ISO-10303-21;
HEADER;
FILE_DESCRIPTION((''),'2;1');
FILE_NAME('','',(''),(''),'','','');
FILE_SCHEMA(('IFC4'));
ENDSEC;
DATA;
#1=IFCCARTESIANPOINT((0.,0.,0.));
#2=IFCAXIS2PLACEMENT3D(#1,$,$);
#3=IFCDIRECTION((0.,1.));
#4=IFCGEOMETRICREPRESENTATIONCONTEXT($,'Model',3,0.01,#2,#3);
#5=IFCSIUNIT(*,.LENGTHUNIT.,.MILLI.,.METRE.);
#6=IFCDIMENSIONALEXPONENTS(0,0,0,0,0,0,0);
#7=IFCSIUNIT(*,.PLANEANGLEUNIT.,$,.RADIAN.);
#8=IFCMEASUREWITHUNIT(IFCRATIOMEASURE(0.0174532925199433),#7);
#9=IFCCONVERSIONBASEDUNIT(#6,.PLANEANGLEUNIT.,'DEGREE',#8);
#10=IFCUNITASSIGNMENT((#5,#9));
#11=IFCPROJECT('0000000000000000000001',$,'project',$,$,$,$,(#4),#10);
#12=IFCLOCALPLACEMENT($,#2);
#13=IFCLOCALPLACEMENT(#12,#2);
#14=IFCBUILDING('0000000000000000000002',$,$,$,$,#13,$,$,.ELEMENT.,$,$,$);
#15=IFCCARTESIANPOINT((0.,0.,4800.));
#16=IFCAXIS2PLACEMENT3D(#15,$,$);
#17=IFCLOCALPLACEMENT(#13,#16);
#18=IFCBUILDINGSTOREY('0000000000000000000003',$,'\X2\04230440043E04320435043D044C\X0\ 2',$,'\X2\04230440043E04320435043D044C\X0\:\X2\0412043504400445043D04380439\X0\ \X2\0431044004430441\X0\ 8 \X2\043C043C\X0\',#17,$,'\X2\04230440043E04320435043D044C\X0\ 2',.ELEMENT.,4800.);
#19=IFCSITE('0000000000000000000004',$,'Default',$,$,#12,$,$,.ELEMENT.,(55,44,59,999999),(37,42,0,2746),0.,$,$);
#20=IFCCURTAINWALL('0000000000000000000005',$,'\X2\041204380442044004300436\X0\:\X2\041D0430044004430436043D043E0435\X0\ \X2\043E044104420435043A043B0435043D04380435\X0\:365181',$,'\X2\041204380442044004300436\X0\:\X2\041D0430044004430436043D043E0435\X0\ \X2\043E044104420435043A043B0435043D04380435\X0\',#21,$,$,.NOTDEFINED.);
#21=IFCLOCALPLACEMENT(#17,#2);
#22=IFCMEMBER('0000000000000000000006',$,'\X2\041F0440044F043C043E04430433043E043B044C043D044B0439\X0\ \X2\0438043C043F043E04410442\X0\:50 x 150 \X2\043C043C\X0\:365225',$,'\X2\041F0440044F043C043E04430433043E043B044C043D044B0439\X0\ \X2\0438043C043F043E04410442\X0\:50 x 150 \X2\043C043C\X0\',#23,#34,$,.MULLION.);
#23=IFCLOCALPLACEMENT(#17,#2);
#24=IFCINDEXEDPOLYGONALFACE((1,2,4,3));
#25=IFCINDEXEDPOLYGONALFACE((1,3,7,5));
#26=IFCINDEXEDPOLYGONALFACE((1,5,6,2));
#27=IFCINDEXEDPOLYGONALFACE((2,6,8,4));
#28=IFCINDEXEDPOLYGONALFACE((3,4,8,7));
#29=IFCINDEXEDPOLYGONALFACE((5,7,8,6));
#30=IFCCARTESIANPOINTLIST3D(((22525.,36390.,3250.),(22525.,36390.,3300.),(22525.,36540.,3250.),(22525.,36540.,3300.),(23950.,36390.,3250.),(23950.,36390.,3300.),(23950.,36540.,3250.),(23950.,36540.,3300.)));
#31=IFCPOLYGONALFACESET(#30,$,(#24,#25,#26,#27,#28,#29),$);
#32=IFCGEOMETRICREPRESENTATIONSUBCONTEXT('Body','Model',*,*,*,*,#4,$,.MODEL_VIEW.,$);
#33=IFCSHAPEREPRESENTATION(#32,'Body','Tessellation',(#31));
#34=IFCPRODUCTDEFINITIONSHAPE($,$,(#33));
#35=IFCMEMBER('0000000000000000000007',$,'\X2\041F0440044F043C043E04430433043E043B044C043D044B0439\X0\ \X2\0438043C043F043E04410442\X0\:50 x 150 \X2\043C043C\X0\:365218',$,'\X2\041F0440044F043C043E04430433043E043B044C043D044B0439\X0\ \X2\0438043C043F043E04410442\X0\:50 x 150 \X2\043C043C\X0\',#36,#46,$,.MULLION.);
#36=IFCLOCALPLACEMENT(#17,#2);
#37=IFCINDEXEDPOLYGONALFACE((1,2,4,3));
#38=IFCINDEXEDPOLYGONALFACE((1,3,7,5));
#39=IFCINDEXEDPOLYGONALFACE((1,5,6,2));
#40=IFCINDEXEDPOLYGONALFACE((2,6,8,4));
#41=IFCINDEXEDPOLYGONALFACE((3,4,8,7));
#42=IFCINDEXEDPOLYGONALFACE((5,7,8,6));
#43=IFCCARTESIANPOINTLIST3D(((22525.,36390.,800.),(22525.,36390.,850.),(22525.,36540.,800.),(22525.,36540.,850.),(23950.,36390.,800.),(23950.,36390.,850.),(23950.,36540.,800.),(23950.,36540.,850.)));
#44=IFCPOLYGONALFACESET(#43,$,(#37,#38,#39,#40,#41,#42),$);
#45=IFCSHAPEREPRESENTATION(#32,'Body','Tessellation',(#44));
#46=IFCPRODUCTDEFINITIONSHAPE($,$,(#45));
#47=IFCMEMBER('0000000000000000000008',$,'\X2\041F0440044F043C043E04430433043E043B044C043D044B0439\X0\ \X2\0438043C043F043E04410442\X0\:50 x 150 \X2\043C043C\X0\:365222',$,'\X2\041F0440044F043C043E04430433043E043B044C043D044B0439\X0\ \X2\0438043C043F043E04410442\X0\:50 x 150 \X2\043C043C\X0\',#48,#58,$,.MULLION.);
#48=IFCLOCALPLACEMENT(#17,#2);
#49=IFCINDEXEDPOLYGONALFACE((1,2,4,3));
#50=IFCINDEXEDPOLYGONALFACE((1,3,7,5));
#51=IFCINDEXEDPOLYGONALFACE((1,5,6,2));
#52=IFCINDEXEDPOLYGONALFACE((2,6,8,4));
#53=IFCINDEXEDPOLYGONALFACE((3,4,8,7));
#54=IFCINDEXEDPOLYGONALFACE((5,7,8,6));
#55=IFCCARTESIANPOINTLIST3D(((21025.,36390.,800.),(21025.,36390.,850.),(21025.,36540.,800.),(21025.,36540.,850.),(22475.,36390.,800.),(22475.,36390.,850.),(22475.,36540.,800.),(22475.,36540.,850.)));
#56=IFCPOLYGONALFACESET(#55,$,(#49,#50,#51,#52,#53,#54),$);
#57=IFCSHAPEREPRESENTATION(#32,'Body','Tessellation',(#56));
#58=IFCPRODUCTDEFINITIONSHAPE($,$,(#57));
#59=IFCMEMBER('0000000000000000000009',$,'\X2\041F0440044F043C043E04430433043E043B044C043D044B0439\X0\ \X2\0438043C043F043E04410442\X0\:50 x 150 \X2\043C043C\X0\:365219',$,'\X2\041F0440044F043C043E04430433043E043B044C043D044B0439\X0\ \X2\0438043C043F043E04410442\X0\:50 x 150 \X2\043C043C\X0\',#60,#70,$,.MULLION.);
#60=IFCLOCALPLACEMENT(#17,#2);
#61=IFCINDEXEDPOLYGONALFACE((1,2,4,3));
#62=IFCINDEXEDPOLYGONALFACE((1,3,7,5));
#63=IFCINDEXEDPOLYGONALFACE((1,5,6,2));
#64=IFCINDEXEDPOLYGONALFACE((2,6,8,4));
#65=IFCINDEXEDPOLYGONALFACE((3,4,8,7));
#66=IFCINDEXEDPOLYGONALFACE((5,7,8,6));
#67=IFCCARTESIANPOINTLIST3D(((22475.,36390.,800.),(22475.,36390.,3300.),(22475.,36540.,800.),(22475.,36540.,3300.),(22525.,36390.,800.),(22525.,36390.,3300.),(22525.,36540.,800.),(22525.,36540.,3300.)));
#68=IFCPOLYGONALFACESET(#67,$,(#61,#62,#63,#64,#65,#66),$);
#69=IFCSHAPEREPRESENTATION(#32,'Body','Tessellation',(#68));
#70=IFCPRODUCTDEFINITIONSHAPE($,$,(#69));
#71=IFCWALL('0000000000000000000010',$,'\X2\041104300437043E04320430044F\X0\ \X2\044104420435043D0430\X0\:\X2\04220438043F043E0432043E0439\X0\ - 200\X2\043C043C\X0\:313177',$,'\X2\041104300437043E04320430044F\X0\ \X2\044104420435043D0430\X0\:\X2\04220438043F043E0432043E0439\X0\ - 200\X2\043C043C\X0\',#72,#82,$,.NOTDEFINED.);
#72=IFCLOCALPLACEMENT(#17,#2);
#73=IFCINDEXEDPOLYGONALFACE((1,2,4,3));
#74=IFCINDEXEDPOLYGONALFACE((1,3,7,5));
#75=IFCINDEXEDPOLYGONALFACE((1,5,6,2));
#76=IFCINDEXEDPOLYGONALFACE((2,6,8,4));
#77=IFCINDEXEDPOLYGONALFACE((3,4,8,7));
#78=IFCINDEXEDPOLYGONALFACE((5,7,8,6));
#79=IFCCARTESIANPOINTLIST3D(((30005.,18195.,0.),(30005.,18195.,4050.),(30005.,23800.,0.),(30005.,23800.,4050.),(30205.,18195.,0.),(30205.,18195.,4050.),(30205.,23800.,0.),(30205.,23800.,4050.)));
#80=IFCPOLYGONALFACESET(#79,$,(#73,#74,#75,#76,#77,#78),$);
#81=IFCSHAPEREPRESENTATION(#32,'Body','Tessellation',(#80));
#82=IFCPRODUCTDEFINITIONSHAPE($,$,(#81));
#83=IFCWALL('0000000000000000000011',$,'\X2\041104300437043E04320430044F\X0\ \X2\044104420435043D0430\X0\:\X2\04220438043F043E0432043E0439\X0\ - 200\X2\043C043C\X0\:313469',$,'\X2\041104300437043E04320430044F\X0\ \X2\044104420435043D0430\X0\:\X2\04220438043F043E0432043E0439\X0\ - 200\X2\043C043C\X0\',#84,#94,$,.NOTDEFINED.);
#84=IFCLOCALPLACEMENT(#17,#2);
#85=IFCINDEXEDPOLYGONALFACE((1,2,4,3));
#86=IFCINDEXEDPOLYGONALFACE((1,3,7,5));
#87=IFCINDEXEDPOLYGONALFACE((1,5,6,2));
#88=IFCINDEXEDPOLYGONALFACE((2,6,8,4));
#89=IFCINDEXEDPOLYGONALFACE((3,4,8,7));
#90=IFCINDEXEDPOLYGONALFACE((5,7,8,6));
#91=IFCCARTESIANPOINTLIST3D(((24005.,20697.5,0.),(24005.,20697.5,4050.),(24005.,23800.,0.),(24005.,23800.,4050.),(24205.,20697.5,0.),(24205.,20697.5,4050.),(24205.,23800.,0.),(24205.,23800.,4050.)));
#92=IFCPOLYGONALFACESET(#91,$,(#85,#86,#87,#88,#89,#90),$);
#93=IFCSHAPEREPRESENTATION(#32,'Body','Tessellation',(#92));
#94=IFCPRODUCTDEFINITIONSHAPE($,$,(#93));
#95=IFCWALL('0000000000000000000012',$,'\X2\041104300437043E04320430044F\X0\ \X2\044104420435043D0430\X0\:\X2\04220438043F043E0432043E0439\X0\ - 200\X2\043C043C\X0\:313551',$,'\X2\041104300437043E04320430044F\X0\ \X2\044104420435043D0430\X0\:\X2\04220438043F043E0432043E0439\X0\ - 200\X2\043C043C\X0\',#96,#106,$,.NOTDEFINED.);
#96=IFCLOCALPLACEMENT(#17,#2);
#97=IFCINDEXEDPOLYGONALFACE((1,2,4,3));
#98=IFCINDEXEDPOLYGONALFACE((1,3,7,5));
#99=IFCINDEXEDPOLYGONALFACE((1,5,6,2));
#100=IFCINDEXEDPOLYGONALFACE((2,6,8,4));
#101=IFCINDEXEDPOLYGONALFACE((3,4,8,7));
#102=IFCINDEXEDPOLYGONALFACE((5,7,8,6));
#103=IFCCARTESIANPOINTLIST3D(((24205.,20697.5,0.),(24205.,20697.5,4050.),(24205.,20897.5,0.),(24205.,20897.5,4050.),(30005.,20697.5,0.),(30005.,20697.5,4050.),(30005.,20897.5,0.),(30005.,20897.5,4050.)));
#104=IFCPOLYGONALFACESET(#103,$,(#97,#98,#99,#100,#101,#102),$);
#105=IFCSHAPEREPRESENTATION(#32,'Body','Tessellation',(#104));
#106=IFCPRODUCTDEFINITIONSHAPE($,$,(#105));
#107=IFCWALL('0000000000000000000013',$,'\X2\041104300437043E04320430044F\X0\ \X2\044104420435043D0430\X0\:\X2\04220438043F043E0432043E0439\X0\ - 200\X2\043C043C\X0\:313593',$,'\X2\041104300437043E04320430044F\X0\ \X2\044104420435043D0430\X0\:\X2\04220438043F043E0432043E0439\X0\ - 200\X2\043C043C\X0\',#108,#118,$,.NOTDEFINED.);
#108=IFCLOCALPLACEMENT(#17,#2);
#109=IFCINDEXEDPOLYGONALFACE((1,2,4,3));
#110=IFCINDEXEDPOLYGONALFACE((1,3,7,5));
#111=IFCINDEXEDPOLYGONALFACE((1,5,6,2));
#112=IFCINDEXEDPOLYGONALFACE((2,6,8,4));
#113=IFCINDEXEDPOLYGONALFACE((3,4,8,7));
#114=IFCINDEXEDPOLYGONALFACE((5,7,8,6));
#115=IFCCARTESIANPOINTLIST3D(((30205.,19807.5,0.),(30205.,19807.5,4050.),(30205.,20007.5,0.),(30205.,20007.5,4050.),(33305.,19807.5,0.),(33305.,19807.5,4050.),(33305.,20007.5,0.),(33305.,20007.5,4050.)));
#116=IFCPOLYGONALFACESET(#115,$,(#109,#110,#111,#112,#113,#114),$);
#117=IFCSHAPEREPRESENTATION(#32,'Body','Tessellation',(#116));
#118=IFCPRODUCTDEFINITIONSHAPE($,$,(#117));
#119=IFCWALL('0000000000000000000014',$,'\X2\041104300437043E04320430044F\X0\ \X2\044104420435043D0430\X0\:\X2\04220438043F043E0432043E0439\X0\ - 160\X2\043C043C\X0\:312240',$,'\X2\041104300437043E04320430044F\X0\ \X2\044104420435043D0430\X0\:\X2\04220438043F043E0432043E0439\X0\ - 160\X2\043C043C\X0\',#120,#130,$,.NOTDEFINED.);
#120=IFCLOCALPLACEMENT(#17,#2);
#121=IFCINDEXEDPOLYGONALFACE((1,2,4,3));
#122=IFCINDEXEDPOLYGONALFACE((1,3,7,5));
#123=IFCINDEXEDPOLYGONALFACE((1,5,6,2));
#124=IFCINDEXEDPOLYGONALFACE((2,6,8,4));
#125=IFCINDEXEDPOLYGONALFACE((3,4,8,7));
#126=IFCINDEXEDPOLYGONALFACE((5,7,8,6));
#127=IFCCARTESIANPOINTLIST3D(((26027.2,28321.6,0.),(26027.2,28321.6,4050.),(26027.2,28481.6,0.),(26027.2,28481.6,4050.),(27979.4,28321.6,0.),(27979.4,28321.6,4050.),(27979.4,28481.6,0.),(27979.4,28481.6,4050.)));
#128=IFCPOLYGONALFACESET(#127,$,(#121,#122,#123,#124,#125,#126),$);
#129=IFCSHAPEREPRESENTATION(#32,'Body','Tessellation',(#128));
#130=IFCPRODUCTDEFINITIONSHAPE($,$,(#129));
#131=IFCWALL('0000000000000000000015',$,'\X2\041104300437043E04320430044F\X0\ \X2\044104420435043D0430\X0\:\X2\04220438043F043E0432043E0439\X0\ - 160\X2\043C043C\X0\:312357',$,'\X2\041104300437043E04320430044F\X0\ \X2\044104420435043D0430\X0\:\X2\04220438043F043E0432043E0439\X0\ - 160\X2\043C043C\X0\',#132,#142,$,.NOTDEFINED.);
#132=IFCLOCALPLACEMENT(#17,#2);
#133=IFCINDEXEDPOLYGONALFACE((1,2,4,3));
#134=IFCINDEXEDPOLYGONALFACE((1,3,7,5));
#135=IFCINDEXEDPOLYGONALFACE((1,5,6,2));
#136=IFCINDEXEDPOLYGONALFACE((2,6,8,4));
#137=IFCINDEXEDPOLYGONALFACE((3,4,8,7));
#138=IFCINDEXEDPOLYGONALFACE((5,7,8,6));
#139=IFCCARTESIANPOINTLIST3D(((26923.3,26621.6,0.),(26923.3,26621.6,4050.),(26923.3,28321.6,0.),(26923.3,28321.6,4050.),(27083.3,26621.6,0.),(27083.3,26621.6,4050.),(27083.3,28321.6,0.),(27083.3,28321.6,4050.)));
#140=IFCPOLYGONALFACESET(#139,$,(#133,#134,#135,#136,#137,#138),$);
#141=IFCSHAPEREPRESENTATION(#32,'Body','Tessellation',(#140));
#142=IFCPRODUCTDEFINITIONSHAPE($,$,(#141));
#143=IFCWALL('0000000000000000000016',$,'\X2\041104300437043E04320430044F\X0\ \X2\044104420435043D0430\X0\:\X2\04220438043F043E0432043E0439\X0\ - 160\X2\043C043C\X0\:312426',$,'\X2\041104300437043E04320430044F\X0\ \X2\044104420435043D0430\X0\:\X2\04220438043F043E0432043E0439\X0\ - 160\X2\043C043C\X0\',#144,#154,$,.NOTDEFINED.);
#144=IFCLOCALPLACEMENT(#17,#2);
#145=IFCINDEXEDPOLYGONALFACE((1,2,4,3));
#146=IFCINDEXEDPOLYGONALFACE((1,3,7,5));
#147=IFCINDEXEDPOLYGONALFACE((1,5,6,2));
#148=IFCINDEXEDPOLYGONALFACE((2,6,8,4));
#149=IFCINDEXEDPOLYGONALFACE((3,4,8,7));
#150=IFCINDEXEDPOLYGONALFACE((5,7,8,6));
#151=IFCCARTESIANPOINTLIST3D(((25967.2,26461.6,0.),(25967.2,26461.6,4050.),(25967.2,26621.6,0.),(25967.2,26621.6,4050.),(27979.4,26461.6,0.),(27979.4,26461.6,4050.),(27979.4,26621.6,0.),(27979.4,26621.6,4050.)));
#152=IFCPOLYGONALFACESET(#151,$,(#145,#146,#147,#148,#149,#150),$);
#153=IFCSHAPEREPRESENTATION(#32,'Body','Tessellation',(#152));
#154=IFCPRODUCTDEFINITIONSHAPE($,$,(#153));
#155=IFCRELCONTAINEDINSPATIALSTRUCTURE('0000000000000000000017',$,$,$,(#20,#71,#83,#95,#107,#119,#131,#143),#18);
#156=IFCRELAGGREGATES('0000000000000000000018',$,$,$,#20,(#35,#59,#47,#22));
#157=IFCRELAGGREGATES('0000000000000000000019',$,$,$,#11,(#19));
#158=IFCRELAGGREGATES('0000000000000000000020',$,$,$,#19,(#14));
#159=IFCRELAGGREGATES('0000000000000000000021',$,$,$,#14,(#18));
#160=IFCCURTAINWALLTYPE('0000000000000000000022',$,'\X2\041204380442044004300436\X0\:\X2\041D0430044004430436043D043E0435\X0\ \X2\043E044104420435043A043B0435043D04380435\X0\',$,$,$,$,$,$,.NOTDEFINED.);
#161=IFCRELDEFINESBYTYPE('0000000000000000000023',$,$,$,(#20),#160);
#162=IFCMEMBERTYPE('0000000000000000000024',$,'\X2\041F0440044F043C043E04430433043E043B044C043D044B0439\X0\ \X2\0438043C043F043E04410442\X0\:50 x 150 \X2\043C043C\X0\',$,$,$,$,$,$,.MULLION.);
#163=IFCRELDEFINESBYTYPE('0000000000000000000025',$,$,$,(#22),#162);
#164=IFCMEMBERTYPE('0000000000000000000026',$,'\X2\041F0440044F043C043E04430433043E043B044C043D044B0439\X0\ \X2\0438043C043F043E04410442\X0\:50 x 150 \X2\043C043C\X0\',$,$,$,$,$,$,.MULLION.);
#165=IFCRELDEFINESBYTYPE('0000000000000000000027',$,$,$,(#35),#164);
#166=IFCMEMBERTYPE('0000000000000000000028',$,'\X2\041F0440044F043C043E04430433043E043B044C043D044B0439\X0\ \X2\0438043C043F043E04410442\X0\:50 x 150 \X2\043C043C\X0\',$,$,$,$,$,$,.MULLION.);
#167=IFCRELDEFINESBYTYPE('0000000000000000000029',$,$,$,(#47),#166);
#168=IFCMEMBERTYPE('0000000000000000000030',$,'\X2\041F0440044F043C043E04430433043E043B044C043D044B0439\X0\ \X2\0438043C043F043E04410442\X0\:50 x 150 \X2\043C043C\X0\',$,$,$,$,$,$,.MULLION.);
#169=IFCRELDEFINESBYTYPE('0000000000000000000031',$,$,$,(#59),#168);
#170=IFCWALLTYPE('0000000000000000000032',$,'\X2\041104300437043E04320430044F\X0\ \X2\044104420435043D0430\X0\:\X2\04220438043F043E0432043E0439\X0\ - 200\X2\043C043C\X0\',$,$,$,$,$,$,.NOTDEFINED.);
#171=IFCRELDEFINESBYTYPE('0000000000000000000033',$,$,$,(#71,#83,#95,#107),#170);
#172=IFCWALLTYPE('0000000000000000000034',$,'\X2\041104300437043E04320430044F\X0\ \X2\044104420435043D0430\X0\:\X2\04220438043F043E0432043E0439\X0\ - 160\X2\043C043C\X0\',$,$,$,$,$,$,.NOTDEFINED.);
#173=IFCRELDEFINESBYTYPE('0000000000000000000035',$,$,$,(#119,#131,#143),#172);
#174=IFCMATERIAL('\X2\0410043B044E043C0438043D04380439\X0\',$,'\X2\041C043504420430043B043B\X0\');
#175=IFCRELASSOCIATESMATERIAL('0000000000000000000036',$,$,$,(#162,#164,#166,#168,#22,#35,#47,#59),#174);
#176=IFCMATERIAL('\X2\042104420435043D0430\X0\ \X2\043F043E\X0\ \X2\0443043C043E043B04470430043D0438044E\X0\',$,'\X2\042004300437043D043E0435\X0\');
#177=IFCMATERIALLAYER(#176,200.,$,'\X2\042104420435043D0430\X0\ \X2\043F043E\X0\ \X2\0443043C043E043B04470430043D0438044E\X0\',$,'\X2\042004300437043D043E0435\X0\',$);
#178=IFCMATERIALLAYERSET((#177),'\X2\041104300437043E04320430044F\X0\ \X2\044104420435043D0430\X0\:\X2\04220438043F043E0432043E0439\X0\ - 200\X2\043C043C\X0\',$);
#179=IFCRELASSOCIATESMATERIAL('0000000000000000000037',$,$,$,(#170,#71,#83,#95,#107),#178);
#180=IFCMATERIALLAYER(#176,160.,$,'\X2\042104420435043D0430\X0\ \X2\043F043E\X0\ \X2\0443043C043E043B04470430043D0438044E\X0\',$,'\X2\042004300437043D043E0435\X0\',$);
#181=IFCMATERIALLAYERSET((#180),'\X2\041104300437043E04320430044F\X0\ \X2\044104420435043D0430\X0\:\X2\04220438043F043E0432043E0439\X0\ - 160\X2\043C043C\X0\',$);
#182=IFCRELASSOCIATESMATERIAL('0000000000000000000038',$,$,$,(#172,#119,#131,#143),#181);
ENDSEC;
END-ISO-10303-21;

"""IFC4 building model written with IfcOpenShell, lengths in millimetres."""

from ifc_helpers import new_model, entity, si_unit, converted_unit, direction, frame, frame_2d, origin, origin_2d_with_axis, place, context, subcontext, project, spatial, rectangle, extrude, source, transform, mapped, material, layer, layer_set, layer_usage, material_profile, profile_set, profile_usage, type_object, type_shapes, element, aggregate, save


model = new_model("IFC4")

# Units and contexts
model_context = context("Model", 3, precision=0.01, world=origin(), true_north=direction((0.0, 1.0)))
body_context = subcontext(model_context, "Body", "Model", "MODEL_VIEW")
ifc_project = project(units=[si_unit("LENGTHUNIT", "METRE", prefix="MILLI"), converted_unit("PLANEANGLEUNIT", "DEGREE", entity("IfcRatioMeasure", 0.0174532925199433), si_unit("PLANEANGLEUNIT", "RADIAN"), dimensions=[0, 0, 0, 0, 0, 0, 0])], contexts=[model_context])

# Site, building, storey
site_placement = place(None, origin())
site = spatial("IfcSite", under=ifc_project, at=site_placement, Name="Default", CompositionType="ELEMENT", RefLatitude=(55, 44, 59, 999999), RefLongitude=(37, 42, 0, 2746), RefElevation=0.0)
building_placement = place(site_placement, origin())
building = spatial("IfcBuilding", under=site, at=building_placement, CompositionType="ELEMENT")
storey_placement = place(building_placement, frame((0.0, 0.0, 4800.0)))
storey = spatial("IfcBuildingStorey", under=building, at=storey_placement, Name="Уровень 2", ObjectType="Уровень:Верхний брус 8 мм", LongName="Уровень 2", CompositionType="ELEMENT", Elevation=4800.0)

# Curtain wall, members
curtain_wall_type = type_object("IfcCurtainWallType", Name="Витраж:Наружное остекление", PredefinedType="NOTDEFINED")
curtain_wall_1_placement = place(storey_placement, frame((0.0, 0.0, -4800.0)))
curtain_wall_1 = element("IfcCurtainWall", 1, at=curtain_wall_1_placement, inside=storey, type_object=curtain_wall_type, Name="Витраж:Наружное остекление:365181", ObjectType="Витраж:Наружное остекление", PredefinedType="NOTDEFINED")
ifc_material_1 = material(Name="Алюминий", Category="Металл")
ifc_material_profile = material_profile(ifc_material_1, rectangle(XDim=150.0, YDim=50.0, at=origin_2d_with_axis()), Name="50 x 150 мм")
ifc_profile_set = profile_set([ifc_material_profile], Name="50 x 150 мм")
ifc_profile_usage_1 = profile_usage(ifc_profile_set)
member_type_1 = type_object("IfcMemberType", Name="Прямоугольный импост:50 x 150 мм", PredefinedType="MULLION", material=ifc_profile_set)
shared_shape_1 = source(origin(), body_context, "Body", "SweptSolid", [
    extrude(rectangle(XDim=150.0, YDim=50.0, at=origin_2d_with_axis()), frame((-25.0, 0.0, -1425.0), z_axis=(0.0, 0.0, 1.0), x_axis=(0.0, -1.0, 0.0)), (0.0, 0.0, 1.0), 1425.0),
])
type_shapes(member_type_1, [shared_shape_1])
member_1_placement = place(storey_placement, frame((22525.0, 36465.0, 3300.0), z_axis=(-1.0, 0.0, 0.0), x_axis=(0.0, 0.0, 1.0)))
member_1 = element("IfcMember", 2, at=member_1_placement, type_object=member_type_1, material=ifc_profile_usage_1, Name="Прямоугольный импост:50 x 150 мм:365225", ObjectType="Прямоугольный импост:50 x 150 мм", PredefinedType="MULLION", context=body_context, shape_type="MappedRepresentation", body=[
    mapped(shared_shape_1, transform((0.0, 0.0, 0.0), scale=1.0)),
])
ifc_profile_usage_2 = profile_usage(ifc_profile_set)
member_type_2 = type_object("IfcMemberType", Name="Прямоугольный импост:50 x 150 мм", PredefinedType="MULLION", material=ifc_profile_set)
shared_shape_2 = source(origin(), body_context, "Body", "SweptSolid", [
    extrude(rectangle(XDim=150.0, YDim=50.0, at=origin_2d_with_axis()), frame((-25.0, 0.0, -1425.0), z_axis=(0.0, 0.0, 1.0), x_axis=(0.0, -1.0, 0.0)), (0.0, 0.0, 1.0), 1425.0),
])
type_shapes(member_type_2, [shared_shape_2])
member_2_placement = place(storey_placement, frame((23950.0, 36465.0, 800.0), z_axis=(1.0, 0.0, 0.0), x_axis=(0.0, 0.0, -1.0)))
member_2 = element("IfcMember", 3, at=member_2_placement, type_object=member_type_2, material=ifc_profile_usage_2, Name="Прямоугольный импост:50 x 150 мм:365218", ObjectType="Прямоугольный импост:50 x 150 мм", PredefinedType="MULLION", context=body_context, shape_type="MappedRepresentation", body=[
    mapped(shared_shape_2, transform((0.0, 0.0, 0.0), scale=1.0)),
])
ifc_profile_usage_3 = profile_usage(ifc_profile_set)
member_type_3 = type_object("IfcMemberType", Name="Прямоугольный импост:50 x 150 мм", PredefinedType="MULLION", material=ifc_profile_set)
shared_shape_3 = source(origin(), body_context, "Body", "SweptSolid", [
    extrude(rectangle(XDim=150.0, YDim=50.0, at=origin_2d_with_axis()), frame((-25.0, 0.0, -1450.0), z_axis=(0.0, 0.0, 1.0), x_axis=(0.0, -1.0, 0.0)), (0.0, 0.0, 1.0), 1450.0),
])
type_shapes(member_type_3, [shared_shape_3])
member_3_placement = place(storey_placement, frame((22475.0, 36465.0, 800.0), z_axis=(1.0, 0.0, 0.0), x_axis=(0.0, 0.0, -1.0)))
member_3 = element("IfcMember", 4, at=member_3_placement, type_object=member_type_3, material=ifc_profile_usage_3, Name="Прямоугольный импост:50 x 150 мм:365222", ObjectType="Прямоугольный импост:50 x 150 мм", PredefinedType="MULLION", context=body_context, shape_type="MappedRepresentation", body=[
    mapped(shared_shape_3, transform((0.0, 0.0, 0.0), scale=1.0)),
])
ifc_profile_usage_4 = profile_usage(ifc_profile_set)
member_type_4 = type_object("IfcMemberType", Name="Прямоугольный импост:50 x 150 мм", PredefinedType="MULLION", material=ifc_profile_set)
shared_shape_4 = source(origin(), body_context, "Body", "SweptSolid", [
    extrude(rectangle(XDim=150.0, YDim=50.0, at=origin_2d_with_axis()), frame((0.0, 0.0, -2500.0), z_axis=(0.0, 0.0, 1.0), x_axis=(0.0, -1.0, 0.0)), (0.0, 0.0, 1.0), 2500.0),
])
type_shapes(member_type_4, [shared_shape_4])
member_4_placement = place(storey_placement, frame((22500.0, 36465.0, 800.0), z_axis=(0.0, 0.0, -1.0), x_axis=(-1.0, 0.0, 0.0)))
member_4 = element("IfcMember", 5, at=member_4_placement, type_object=member_type_4, material=ifc_profile_usage_4, Name="Прямоугольный импост:50 x 150 мм:365219", ObjectType="Прямоугольный импост:50 x 150 мм", PredefinedType="MULLION", context=body_context, shape_type="MappedRepresentation", body=[
    mapped(shared_shape_4, transform((0.0, 0.0, 0.0), scale=1.0)),
])

aggregate(curtain_wall_1, [member_2, member_4, member_3, member_1])

# Shared definitions
ifc_material_2 = material(Name="Стена по умолчанию", Category="Разное")
ifc_layer_1 = layer(ifc_material_2, 200.0, Name="Стена по умолчанию", Category="Разное")
ifc_layer_set_1 = layer_set([ifc_layer_1], Name="Базовая стена:Типовой - 200мм")
wall_type_1 = type_object("IfcWallType", Name="Базовая стена:Типовой - 200мм", PredefinedType="NOTDEFINED", material=ifc_layer_set_1)

# Walls
ifc_layer_usage_1 = layer_usage(ifc_layer_set_1, "AXIS2", "NEGATIVE", 100.0)
wall_1_placement = place(storey_placement, frame((30105.0, 23800.0, 0.0), z_axis=(0.0, 0.0, 1.0), x_axis=(0.0, -1.0, 0.0)))
element("IfcWall", 6, at=wall_1_placement, inside=storey, type_object=wall_type_1, material=ifc_layer_usage_1, Name="Базовая стена:Типовой - 200мм:313177", ObjectType="Базовая стена:Типовой - 200мм", PredefinedType="NOTDEFINED", context=body_context, shape_type="SweptSolid", body=[
    extrude(rectangle(XDim=5605.0, YDim=200.0, at=frame_2d((2802.5, 0.0), x_axis=(-1.0, 0.0))), origin(), (0.0, 0.0, 1.0), 4050.0),
])
ifc_layer_usage_2 = layer_usage(ifc_layer_set_1, "AXIS2", "NEGATIVE", 100.0)
wall_2_placement = place(storey_placement, frame((24105.0, 23800.0, 0.0), z_axis=(0.0, 0.0, 1.0), x_axis=(0.0, -1.0, 0.0)))
element("IfcWall", 7, at=wall_2_placement, inside=storey, type_object=wall_type_1, material=ifc_layer_usage_2, Name="Базовая стена:Типовой - 200мм:313469", ObjectType="Базовая стена:Типовой - 200мм", PredefinedType="NOTDEFINED", context=body_context, shape_type="SweptSolid", body=[
    extrude(rectangle(XDim=3102.5, YDim=200.0, at=frame_2d((1551.3, 0.0), x_axis=(-1.0, 0.0))), origin(), (0.0, 0.0, 1.0), 4050.0),
])
ifc_layer_usage_3 = layer_usage(ifc_layer_set_1, "AXIS2", "NEGATIVE", 100.0)
wall_3_placement = place(storey_placement, frame((24205.0, 20797.5, 0.0)))
element("IfcWall", 8, at=wall_3_placement, inside=storey, type_object=wall_type_1, material=ifc_layer_usage_3, Name="Базовая стена:Типовой - 200мм:313551", ObjectType="Базовая стена:Типовой - 200мм", PredefinedType="NOTDEFINED", context=body_context, shape_type="SweptSolid", body=[
    extrude(rectangle(XDim=5800.0, YDim=200.0, at=frame_2d((2900.0, 0.0), x_axis=(-1.0, 0.0))), origin(), (0.0, 0.0, 1.0), 4050.0),
])
ifc_layer_usage_4 = layer_usage(ifc_layer_set_1, "AXIS2", "NEGATIVE", 100.0)
wall_4_placement = place(storey_placement, frame((30205.0, 19907.5, 0.0)))
element("IfcWall", 9, at=wall_4_placement, inside=storey, type_object=wall_type_1, material=ifc_layer_usage_4, Name="Базовая стена:Типовой - 200мм:313593", ObjectType="Базовая стена:Типовой - 200мм", PredefinedType="NOTDEFINED", context=body_context, shape_type="SweptSolid", body=[
    extrude(rectangle(XDim=3100.0, YDim=200.0, at=frame_2d((1550.0, 0.0), x_axis=(-1.0, 0.0))), origin(), (0.0, 0.0, 1.0), 4050.0),
])
ifc_layer_2 = layer(ifc_material_2, 160.0, Name="Стена по умолчанию", Category="Разное")
ifc_layer_set_2 = layer_set([ifc_layer_2], Name="Базовая стена:Типовой - 160мм")
ifc_layer_usage_5 = layer_usage(ifc_layer_set_2, "AXIS2", "NEGATIVE", 80.0)
wall_type_2 = type_object("IfcWallType", Name="Базовая стена:Типовой - 160мм", PredefinedType="NOTDEFINED", material=ifc_layer_set_2)
wall_5_placement = place(storey_placement, frame((26027.2, 28401.6, 0.0)))
element("IfcWall", 10, at=wall_5_placement, inside=storey, type_object=wall_type_2, material=ifc_layer_usage_5, Name="Базовая стена:Типовой - 160мм:312240", ObjectType="Базовая стена:Типовой - 160мм", PredefinedType="NOTDEFINED", context=body_context, shape_type="SweptSolid", body=[
    extrude(rectangle(XDim=1952.2, YDim=160.0, at=frame_2d((976.1, 0.0), x_axis=(-1.0, 0.0))), origin(), (0.0, 0.0, 1.0), 4050.0),
])
ifc_layer_usage_6 = layer_usage(ifc_layer_set_2, "AXIS2", "NEGATIVE", 80.0)
wall_6_placement = place(storey_placement, frame((27003.3, 28321.6, 0.0), z_axis=(0.0, 0.0, 1.0), x_axis=(0.0, -1.0, 0.0)))
element("IfcWall", 11, at=wall_6_placement, inside=storey, type_object=wall_type_2, material=ifc_layer_usage_6, Name="Базовая стена:Типовой - 160мм:312357", ObjectType="Базовая стена:Типовой - 160мм", PredefinedType="NOTDEFINED", context=body_context, shape_type="SweptSolid", body=[
    extrude(rectangle(XDim=1700.0, YDim=160.0, at=frame_2d((850.0, 0.0), x_axis=(-1.0, 0.0))), origin(), (0.0, 0.0, 1.0), 4050.0),
])
ifc_layer_usage_7 = layer_usage(ifc_layer_set_2, "AXIS2", "NEGATIVE", 80.0)
wall_7_placement = place(storey_placement, frame((25967.2, 26541.6, 0.0)))
element("IfcWall", 12, at=wall_7_placement, inside=storey, type_object=wall_type_2, material=ifc_layer_usage_7, Name="Базовая стена:Типовой - 160мм:312426", ObjectType="Базовая стена:Типовой - 160мм", PredefinedType="NOTDEFINED", context=body_context, shape_type="SweptSolid", body=[
    extrude(rectangle(XDim=2012.2, YDim=160.0, at=frame_2d((1006.1, 0.0), x_axis=(-1.0, 0.0))), origin(), (0.0, 0.0, 1.0), 4050.0),
])

save(model, "model.ifc")
